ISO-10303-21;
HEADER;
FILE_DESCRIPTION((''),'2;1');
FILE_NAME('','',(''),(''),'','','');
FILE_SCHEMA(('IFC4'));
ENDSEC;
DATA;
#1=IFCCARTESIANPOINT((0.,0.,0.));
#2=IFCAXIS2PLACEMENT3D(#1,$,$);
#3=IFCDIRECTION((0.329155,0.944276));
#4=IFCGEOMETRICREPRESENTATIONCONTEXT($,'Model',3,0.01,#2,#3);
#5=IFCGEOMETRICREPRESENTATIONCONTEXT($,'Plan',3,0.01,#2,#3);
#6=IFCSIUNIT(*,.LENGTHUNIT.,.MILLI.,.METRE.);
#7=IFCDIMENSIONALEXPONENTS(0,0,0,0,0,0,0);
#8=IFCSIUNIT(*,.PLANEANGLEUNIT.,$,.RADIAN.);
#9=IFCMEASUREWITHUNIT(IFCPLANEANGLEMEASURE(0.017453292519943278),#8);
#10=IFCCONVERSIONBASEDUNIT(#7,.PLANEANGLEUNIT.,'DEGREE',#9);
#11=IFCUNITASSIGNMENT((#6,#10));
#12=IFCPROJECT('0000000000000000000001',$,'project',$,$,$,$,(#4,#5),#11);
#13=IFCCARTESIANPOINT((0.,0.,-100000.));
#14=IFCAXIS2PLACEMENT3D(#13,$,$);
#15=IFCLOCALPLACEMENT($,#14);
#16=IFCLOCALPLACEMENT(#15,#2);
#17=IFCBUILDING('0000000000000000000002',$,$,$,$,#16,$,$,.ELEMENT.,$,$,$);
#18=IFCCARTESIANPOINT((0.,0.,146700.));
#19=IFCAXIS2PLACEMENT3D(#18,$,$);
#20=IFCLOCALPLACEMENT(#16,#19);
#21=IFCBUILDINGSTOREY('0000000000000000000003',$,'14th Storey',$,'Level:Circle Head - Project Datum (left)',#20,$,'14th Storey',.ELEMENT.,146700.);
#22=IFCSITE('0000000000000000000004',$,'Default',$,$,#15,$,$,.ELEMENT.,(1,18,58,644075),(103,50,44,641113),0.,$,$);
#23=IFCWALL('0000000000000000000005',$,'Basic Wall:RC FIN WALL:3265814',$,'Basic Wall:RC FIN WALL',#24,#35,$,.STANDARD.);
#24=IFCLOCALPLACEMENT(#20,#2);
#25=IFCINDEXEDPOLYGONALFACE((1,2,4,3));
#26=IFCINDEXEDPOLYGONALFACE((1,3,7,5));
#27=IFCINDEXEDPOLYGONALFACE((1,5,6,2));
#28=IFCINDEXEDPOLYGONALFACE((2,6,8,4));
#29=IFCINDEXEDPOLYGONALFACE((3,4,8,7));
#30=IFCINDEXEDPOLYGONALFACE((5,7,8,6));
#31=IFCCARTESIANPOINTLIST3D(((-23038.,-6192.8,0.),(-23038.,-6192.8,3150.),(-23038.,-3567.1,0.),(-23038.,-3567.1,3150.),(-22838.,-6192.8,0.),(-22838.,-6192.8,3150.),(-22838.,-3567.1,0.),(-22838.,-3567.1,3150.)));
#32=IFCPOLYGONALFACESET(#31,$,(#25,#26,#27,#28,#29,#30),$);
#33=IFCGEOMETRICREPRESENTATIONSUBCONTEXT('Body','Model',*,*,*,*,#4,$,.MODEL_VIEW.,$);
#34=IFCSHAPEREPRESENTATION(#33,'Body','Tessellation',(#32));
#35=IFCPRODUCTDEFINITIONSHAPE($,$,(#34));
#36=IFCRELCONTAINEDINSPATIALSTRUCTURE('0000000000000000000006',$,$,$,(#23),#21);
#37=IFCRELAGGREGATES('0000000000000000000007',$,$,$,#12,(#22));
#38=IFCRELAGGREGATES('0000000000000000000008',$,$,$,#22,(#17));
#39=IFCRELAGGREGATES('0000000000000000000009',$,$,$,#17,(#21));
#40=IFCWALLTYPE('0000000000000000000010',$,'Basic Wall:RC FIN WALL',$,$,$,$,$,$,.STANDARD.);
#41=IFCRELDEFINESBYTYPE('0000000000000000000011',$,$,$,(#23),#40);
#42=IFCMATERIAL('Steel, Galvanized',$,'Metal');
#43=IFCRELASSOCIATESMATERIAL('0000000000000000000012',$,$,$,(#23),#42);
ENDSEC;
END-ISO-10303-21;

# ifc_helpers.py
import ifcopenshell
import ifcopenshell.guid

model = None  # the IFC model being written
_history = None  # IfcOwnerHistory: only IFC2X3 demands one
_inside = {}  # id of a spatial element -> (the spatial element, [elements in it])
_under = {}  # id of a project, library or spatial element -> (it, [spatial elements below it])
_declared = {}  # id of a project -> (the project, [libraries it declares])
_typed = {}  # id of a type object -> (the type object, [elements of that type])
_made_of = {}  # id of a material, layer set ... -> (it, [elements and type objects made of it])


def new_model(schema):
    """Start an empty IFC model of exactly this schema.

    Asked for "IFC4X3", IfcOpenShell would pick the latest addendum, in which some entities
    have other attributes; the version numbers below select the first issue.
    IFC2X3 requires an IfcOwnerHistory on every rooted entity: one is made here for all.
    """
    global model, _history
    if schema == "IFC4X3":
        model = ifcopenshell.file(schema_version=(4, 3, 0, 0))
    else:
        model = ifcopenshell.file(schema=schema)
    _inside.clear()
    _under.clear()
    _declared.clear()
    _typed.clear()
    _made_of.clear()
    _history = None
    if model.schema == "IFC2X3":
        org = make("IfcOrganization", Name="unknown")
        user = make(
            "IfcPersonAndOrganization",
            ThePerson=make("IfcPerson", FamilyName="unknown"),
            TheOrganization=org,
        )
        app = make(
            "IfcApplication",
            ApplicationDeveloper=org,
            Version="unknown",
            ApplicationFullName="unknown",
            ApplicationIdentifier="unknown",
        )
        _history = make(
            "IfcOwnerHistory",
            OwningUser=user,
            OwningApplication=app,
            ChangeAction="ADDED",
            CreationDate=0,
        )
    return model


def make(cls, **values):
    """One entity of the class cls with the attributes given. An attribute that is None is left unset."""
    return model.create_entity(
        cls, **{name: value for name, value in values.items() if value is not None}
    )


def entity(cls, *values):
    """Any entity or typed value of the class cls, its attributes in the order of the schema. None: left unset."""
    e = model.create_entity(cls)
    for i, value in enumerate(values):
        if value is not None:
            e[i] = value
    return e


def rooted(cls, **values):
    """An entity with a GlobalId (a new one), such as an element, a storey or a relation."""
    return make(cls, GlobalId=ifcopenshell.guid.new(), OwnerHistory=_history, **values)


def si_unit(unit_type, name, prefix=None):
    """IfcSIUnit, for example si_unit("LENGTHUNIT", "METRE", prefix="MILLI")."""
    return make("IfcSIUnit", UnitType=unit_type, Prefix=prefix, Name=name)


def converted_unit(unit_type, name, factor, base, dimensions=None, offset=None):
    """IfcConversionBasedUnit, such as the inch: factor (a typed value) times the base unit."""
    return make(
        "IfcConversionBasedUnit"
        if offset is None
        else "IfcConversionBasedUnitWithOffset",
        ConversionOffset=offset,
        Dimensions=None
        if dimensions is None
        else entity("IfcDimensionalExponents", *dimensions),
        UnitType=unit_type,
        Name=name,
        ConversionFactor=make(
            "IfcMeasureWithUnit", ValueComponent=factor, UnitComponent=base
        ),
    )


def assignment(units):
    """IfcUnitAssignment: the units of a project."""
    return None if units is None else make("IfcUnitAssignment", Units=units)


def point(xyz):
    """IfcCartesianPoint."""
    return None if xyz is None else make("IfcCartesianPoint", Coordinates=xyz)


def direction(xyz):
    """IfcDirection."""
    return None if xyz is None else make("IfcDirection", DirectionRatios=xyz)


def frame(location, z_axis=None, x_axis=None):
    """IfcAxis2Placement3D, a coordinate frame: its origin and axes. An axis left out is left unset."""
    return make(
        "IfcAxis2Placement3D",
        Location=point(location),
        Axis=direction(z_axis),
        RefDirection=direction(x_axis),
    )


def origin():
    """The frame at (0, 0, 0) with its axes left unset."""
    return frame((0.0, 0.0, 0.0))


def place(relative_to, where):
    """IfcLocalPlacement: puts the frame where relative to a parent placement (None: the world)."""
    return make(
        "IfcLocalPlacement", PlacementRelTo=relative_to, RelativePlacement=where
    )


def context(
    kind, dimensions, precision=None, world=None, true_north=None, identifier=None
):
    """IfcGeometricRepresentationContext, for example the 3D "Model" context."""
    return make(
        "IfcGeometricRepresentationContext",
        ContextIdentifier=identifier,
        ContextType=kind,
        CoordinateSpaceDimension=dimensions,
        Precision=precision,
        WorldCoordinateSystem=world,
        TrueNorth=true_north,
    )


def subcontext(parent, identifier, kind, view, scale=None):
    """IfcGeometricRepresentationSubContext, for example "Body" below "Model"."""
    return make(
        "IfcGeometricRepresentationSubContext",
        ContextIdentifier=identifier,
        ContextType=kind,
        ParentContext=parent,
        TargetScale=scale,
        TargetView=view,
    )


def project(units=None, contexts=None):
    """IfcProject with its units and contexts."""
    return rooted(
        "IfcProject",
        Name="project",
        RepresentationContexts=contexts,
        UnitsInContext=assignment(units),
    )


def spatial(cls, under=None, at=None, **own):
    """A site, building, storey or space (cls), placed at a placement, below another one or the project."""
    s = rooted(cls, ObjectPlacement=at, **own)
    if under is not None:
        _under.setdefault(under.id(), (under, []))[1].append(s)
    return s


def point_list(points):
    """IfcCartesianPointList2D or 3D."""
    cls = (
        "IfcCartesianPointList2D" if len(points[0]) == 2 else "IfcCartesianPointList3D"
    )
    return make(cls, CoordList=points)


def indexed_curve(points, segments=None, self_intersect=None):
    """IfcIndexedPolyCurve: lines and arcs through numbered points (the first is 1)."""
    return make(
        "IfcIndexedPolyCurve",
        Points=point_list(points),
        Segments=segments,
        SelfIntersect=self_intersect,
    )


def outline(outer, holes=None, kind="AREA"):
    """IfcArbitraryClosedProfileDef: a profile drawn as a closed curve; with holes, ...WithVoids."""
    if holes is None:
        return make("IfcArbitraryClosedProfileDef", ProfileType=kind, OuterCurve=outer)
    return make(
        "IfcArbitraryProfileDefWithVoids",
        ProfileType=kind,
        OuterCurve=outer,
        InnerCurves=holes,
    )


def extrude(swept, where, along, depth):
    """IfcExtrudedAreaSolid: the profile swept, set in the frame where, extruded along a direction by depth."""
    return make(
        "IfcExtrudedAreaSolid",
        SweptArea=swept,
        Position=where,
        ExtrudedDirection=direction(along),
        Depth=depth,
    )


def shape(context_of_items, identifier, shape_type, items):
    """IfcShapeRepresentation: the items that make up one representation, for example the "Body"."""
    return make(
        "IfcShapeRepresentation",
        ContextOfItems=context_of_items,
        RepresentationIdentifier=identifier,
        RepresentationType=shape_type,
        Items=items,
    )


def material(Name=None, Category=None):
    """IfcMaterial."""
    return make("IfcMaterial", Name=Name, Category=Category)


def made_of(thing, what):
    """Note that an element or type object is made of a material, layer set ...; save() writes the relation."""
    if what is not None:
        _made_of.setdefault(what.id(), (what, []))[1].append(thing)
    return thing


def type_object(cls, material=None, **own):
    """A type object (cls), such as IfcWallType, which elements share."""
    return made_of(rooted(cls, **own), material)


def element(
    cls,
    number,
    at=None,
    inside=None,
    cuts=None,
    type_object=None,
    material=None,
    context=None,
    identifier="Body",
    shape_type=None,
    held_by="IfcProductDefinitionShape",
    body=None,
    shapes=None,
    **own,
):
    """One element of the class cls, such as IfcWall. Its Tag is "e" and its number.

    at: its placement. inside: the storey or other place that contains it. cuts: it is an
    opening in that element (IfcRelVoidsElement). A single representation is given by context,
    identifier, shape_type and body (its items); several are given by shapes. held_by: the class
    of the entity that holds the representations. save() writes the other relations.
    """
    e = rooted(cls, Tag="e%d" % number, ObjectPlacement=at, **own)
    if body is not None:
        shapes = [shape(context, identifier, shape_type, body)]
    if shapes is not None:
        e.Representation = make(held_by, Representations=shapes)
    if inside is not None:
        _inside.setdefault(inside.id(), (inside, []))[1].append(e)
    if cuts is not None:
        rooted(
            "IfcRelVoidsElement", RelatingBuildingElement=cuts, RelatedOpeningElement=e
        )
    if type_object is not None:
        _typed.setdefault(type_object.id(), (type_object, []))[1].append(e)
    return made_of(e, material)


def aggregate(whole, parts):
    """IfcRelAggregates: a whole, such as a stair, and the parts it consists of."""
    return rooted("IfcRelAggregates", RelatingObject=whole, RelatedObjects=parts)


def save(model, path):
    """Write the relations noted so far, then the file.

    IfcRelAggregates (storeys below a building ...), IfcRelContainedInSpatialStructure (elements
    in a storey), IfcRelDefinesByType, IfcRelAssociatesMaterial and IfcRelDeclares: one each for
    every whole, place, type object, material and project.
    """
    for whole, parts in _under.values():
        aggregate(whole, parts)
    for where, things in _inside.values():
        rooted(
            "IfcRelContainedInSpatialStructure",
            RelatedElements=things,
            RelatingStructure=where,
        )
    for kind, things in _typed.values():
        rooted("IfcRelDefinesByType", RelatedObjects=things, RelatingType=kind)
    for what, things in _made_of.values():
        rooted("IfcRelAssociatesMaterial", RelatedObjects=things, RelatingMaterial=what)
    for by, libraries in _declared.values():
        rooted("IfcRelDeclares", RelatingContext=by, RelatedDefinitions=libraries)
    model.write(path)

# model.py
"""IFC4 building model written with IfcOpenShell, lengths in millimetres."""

from ifc_helpers import new_model, entity, si_unit, converted_unit, direction, frame, origin, place, context, subcontext, project, spatial, indexed_curve, outline, extrude, material, type_object, element, save


model = new_model("IFC4")

# Units and contexts
model_context = context("Model", 3, precision=0.01, world=origin(), true_north=direction((0.329155, 0.944276)))
plan_context = context("Plan", 3, precision=0.01, world=origin(), true_north=direction((0.329155, 0.944276)))
body_context = subcontext(model_context, "Body", "Model", "MODEL_VIEW")
ifc_project = project(units=[si_unit("LENGTHUNIT", "METRE", prefix="MILLI"), converted_unit("PLANEANGLEUNIT", "DEGREE", entity("IfcPlaneAngleMeasure", 0.017453292519943278), si_unit("PLANEANGLEUNIT", "RADIAN"), dimensions=[0, 0, 0, 0, 0, 0, 0])], contexts=[model_context, plan_context])

# Site, building, storey
site_placement = place(None, frame((0.0, 0.0, -100000.0)))
site = spatial("IfcSite", under=ifc_project, at=site_placement, Name="Default", CompositionType="ELEMENT", RefLatitude=(1, 18, 58, 644075), RefLongitude=(103, 50, 44, 641113), RefElevation=0.0)
building_placement = place(site_placement, origin())
building = spatial("IfcBuilding", under=site, at=building_placement, CompositionType="ELEMENT")
storey_placement = place(building_placement, frame((0.0, 0.0, 146700.0)))
storey = spatial("IfcBuildingStorey", under=building, at=storey_placement, Name="14th Storey", ObjectType="Level:Circle Head - Project Datum (left)", LongName="14th Storey", CompositionType="ELEMENT", Elevation=146700.0)

# Wall
ifc_material_1 = material(Name="Steel, Galvanized", Category="Metal")
wall_type = type_object("IfcWallType", Name="Basic Wall:RC FIN WALL", PredefinedType="STANDARD")
wall_placement = place(storey_placement, frame((-22938.0, -3567.1, 0.0), z_axis=(0.0, 0.0, 1.0), x_axis=(0.0, -1.0, 0.0)))
element("IfcWall", 1, at=wall_placement, inside=storey, type_object=wall_type, material=ifc_material_1, Name="Basic Wall:RC FIN WALL:3265814", ObjectType="Basic Wall:RC FIN WALL", PredefinedType="STANDARD", context=body_context, shape_type="SweptSolid", body=[
    extrude(outline(indexed_curve([(2625.7, 100.0), (0.0, 100.0), (0.0, -100.0), (2625.7, -100.0), (2625.7, 100.0)], self_intersect=False)), origin(), (0.0, 0.0, 1.0), 3150.0),
])

save(model, "model.ifc")
